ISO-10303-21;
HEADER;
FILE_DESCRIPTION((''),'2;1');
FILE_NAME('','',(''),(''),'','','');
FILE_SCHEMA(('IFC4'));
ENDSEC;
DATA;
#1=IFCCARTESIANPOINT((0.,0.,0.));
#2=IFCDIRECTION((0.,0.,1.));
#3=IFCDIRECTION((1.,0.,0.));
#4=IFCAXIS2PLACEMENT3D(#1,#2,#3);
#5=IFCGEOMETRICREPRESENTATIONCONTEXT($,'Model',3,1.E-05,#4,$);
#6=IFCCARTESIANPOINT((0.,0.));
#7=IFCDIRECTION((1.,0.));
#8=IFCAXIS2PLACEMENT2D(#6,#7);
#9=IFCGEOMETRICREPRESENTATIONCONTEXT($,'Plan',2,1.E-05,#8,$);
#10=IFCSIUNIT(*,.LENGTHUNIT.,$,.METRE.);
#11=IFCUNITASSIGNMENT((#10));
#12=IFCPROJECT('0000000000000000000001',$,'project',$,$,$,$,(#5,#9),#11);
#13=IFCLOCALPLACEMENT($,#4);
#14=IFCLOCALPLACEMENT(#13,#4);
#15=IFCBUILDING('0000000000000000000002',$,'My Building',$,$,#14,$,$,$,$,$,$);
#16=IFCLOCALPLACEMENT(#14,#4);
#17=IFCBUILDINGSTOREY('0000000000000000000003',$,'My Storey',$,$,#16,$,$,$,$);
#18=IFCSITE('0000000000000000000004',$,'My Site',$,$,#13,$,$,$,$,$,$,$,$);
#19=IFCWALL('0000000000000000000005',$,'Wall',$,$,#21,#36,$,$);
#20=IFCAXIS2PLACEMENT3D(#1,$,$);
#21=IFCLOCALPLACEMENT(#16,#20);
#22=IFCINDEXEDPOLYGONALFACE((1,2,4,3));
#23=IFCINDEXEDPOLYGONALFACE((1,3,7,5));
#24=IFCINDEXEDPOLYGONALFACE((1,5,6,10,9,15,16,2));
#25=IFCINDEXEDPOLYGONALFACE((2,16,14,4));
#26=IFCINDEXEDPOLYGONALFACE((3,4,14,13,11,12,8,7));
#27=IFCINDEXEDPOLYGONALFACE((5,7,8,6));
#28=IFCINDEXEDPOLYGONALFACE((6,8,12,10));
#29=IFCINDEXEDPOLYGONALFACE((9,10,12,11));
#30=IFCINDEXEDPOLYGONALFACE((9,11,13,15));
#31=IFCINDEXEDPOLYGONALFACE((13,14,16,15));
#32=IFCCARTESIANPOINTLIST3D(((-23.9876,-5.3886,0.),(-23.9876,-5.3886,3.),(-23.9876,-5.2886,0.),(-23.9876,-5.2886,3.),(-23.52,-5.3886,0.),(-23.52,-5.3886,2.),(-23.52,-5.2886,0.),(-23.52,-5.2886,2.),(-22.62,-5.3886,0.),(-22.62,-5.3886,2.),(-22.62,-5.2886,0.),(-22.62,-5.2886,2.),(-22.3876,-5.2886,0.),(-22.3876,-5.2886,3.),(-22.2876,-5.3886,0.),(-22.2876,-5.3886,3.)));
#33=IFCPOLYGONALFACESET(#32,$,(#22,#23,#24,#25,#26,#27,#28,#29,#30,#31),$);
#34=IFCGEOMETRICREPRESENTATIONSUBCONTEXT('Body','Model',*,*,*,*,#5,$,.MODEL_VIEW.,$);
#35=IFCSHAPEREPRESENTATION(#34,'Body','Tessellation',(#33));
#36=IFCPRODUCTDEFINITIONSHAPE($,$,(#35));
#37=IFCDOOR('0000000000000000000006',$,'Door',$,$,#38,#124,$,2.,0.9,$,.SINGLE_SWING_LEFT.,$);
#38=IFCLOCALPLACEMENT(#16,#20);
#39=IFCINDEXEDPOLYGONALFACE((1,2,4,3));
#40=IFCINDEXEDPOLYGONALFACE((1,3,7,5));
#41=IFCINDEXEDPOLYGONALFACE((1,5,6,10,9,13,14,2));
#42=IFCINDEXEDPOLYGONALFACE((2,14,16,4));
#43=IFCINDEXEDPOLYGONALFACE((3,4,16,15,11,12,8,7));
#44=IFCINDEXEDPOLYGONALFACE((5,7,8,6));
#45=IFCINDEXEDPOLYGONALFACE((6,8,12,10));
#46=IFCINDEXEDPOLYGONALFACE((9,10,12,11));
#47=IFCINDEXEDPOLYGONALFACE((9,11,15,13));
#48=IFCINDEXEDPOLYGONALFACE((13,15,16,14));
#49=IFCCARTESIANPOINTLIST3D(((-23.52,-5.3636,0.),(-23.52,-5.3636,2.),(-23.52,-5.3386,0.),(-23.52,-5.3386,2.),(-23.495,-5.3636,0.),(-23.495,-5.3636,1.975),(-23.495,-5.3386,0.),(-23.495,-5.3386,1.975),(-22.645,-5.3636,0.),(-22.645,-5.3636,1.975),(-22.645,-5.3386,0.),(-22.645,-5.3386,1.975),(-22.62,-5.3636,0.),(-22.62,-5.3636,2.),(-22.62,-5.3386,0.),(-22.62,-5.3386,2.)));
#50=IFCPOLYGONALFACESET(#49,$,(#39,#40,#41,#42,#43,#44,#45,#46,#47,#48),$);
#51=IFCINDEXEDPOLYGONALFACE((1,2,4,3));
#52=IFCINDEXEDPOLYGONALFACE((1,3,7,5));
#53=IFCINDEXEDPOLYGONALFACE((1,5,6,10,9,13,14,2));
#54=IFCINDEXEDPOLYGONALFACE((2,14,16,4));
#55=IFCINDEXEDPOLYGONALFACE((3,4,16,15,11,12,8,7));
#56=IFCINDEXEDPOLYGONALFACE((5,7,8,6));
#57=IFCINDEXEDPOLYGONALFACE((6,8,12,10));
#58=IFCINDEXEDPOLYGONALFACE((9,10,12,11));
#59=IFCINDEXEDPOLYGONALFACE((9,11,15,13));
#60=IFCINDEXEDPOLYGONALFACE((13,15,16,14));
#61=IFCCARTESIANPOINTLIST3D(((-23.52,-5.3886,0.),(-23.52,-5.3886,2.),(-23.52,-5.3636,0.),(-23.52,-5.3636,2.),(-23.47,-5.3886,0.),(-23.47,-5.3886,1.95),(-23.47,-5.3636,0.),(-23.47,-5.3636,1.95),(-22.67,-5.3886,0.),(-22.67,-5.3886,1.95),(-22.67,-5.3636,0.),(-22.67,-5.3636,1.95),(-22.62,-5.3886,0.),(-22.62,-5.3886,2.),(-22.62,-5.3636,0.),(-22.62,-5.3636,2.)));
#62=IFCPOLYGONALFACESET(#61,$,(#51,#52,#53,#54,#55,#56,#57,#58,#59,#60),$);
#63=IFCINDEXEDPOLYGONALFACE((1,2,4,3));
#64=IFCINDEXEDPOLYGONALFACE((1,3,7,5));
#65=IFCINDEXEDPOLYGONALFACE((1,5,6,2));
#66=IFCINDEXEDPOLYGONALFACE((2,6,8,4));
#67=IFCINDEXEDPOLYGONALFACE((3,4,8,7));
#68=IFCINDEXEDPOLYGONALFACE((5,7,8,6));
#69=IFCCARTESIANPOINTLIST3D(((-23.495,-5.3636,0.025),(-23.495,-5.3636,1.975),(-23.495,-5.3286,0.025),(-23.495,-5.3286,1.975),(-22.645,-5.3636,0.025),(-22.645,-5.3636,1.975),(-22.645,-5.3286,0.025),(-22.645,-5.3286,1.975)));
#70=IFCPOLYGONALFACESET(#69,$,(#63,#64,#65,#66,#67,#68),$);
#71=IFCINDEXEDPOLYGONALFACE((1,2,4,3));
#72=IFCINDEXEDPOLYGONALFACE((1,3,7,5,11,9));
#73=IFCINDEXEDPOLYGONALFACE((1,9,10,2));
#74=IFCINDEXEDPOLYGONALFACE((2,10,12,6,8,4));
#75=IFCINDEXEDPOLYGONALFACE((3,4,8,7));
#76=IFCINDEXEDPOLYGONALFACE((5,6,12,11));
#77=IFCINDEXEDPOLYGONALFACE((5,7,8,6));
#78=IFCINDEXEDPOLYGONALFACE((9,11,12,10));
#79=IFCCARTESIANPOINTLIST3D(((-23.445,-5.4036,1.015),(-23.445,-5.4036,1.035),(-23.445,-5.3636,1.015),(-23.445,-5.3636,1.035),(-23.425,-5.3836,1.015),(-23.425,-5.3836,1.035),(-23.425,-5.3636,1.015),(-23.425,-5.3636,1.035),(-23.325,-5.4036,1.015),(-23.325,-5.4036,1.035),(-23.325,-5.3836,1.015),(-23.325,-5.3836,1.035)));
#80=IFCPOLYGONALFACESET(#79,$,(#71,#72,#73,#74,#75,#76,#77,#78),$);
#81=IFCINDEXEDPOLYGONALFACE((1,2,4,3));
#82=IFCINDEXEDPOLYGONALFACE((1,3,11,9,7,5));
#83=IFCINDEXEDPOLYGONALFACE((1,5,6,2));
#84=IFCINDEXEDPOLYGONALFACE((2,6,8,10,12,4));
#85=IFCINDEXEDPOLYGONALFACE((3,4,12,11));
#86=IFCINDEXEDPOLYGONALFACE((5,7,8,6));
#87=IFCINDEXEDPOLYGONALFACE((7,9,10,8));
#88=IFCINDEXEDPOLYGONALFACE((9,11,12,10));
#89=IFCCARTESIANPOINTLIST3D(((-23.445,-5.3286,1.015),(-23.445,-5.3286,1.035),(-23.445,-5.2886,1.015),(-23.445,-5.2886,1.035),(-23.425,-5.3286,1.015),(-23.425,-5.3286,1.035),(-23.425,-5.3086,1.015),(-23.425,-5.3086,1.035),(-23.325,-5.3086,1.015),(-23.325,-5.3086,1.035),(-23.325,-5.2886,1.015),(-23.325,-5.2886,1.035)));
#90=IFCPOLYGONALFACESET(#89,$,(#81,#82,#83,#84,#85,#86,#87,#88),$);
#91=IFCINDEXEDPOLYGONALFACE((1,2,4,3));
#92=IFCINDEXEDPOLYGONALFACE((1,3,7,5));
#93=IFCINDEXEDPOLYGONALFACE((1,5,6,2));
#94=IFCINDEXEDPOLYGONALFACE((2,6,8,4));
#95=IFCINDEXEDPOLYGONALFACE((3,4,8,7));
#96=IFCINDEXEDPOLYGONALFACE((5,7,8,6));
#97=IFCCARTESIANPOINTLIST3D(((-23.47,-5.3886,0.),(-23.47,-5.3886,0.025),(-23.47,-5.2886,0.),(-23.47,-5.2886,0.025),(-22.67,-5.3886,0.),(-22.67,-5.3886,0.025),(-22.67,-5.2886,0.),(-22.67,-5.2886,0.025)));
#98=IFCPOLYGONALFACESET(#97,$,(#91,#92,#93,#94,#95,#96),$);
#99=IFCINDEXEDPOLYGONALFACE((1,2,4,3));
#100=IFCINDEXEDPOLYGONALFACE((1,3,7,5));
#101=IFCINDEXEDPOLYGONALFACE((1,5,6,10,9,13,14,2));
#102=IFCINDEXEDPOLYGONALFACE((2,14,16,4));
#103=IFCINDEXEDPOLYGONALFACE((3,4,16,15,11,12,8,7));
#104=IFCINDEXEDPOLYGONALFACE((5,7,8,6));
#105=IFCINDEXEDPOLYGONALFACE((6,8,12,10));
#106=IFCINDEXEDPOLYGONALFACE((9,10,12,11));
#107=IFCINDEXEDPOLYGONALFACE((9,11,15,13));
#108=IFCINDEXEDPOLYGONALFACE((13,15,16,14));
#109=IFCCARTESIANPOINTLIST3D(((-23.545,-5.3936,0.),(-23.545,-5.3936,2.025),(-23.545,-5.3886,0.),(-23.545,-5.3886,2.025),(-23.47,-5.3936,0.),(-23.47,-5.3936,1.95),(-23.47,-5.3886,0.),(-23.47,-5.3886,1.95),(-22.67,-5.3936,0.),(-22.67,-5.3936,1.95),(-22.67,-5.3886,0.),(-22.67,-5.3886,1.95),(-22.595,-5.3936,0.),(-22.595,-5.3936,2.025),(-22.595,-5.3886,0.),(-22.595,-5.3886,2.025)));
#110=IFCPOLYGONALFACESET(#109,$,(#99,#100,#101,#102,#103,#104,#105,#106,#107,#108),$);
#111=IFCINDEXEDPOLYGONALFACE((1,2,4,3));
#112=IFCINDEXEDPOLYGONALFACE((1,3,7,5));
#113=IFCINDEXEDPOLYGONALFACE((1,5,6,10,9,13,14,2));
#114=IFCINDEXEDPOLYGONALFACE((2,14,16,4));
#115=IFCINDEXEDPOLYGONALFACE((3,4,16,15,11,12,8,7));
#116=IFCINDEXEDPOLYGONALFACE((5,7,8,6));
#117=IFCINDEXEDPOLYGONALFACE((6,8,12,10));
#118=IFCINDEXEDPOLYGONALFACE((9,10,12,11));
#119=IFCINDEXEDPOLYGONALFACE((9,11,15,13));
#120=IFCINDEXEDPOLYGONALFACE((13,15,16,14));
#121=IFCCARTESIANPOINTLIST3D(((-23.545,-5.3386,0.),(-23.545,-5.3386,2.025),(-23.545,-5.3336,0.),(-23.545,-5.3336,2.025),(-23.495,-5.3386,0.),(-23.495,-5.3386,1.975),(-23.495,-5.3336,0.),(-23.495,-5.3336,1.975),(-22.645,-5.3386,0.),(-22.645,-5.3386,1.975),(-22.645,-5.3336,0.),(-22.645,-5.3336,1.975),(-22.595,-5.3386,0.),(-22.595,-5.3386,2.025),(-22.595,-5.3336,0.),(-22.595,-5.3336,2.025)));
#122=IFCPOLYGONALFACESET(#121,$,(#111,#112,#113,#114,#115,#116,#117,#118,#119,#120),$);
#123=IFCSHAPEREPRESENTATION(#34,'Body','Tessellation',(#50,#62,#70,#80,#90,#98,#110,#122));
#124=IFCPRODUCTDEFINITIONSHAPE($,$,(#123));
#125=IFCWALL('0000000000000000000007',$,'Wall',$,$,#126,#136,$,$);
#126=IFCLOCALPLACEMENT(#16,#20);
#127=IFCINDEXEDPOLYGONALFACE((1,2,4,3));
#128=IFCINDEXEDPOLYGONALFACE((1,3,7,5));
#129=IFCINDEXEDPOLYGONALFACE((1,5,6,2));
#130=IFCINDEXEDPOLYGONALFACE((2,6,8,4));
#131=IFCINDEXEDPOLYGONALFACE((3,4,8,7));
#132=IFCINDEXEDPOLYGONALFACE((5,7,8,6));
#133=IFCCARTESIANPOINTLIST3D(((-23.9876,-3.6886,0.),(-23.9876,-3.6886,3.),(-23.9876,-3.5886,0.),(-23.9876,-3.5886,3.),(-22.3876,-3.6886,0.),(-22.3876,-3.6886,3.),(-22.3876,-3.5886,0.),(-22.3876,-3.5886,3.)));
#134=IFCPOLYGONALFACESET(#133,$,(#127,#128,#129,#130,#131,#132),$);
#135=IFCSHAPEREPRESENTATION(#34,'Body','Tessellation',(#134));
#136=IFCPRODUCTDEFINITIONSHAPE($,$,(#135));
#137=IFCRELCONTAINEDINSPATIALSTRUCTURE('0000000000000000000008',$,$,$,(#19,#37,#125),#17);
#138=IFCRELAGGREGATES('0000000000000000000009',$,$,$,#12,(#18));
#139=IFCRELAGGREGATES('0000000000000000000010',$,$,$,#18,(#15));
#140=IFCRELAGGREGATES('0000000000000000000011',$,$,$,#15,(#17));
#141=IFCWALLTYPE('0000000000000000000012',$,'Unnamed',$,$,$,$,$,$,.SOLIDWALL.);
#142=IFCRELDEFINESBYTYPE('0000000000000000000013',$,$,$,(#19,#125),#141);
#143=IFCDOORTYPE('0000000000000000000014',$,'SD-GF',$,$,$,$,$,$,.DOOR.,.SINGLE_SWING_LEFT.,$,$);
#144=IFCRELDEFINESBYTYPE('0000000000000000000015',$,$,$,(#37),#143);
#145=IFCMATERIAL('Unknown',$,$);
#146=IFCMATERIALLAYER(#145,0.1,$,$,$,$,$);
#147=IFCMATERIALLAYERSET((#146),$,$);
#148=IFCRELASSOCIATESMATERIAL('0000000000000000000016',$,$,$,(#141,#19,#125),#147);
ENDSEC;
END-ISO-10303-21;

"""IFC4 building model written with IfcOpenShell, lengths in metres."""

from ifc_helpers import new_model, entity, si_unit, frame, origin_with_axes, origin_2d_with_axis, place, context, subcontext, project, spatial, line, indexed_curve, outline, extrude, shape, source, transform, mapped, material, layer, layer_set, layer_usage, type_object, type_shapes, element, fill, save


model = new_model("IFC4")

# Units and contexts
model_context = context("Model", 3, precision=1e-05, world=origin_with_axes())
plan_context = context("Plan", 2, precision=1e-05, world=origin_2d_with_axis())
body_context_1 = subcontext(model_context, "Body", "Model", "MODEL_VIEW")
body_context_2 = subcontext(plan_context, "Body", "Plan", "PLAN_VIEW")
ifc_project = project(units=[si_unit("LENGTHUNIT", "METRE")], contexts=[model_context, plan_context])

# Site, building, storey
site_placement = place(None, origin_with_axes())
site = spatial("IfcSite", under=ifc_project, at=site_placement, Name="My Site")
building_placement = place(site_placement, origin_with_axes())
building = spatial("IfcBuilding", under=site, at=building_placement, Name="My Building")
storey_placement = place(building_placement, origin_with_axes())
storey = spatial("IfcBuildingStorey", under=building, at=storey_placement, Name="My Storey")

# Shared definitions
ifc_material = material(Name="Unknown")

# Shared definitions
ifc_layer = layer(ifc_material, 0.1)
ifc_layer_set = layer_set([ifc_layer])
wall_type = type_object("IfcWallType", Name="Unnamed", PredefinedType="SOLIDWALL", material=ifc_layer_set)

# Wall, opening, door
shared_shape_1 = source(origin_with_axes(), body_context_1, "Body", "SweptSolid", [
    extrude(outline(indexed_curve([(0.0, 0.0), (0.9, 0.0), (0.9, 2.0), (0.0, 2.0)], segments=[line(1, 2, 3, 4, 1)])), frame((0.0, -0.6, 0.0), z_axis=(0.0, -1.0, 0.0), x_axis=(1.0, 0.0, 0.0)), (0.0, 0.0, -1.0), 1.2),
])
door_type = type_object("IfcDoorType", Name="SD-GF", OperationType="SINGLE_SWING_LEFT", PredefinedType="DOOR")
shared_shape_2 = source(origin_with_axes(), body_context_1, "Body", "SweptSolid", [
    extrude(outline(indexed_curve([(0.0, 0.0), (0.0, 2.0), (0.9, 2.0), (0.9, 0.0), (0.875, 0.0), (0.875, 1.975), (0.025, 1.975), (0.025, 0.0)], segments=[line(1, 2, 3, 4, 5, 6, 7, 8, 1)])), frame((0.0, 0.025, 0.0), z_axis=(0.0, -1.0, 0.0), x_axis=(1.0, 0.0, 0.0)), (0.0, 0.0, -1.0), 0.025),
    extrude(outline(indexed_curve([(0.0, 0.0), (0.0, 2.0), (0.9, 2.0), (0.9, 0.0), (0.85, 0.0), (0.85, 1.95), (0.05, 1.95), (0.05, 0.0)], segments=[line(1, 2, 3, 4, 5, 6, 7, 8, 1)])), frame((0.0, 0.0, 0.0), z_axis=(0.0, -1.0, 0.0), x_axis=(1.0, 0.0, 0.0)), (0.0, 0.0, -1.0), 0.025),
    extrude(outline(indexed_curve([(0.0, 0.0), (0.85, 0.0), (0.85, 0.035), (0.0, 0.035)], segments=[line(1, 2, 3, 4, 1)])), frame((0.025, 0.025, 0.025), z_axis=(0.0, 0.0, 1.0), x_axis=(1.0, 0.0, 0.0)), (0.0, 0.0, 1.0), 1.95),
    extrude(outline(indexed_curve([(0.0, 0.0), (0.0, -0.04), (0.12, -0.04), (0.12, -0.02), (0.02, -0.02), (0.02, 0.0)], segments=[line(1, 2, 3, 4, 5, 6, 1)])), frame((0.075, 0.025, 1.015), z_axis=(0.0, 0.0, 1.0), x_axis=(1.0, 0.0, 0.0)), (0.0, 0.0, 1.0), 0.02),
    extrude(outline(indexed_curve([(0.0, 0.0), (0.0, 0.04), (0.12, 0.04), (0.12, 0.02), (0.02, 0.02), (0.02, 0.0)], segments=[line(1, 2, 3, 4, 5, 6, 1)])), frame((0.075, 0.06, 1.015), z_axis=(0.0, 0.0, 1.0), x_axis=(1.0, 0.0, 0.0)), (0.0, 0.0, 1.0), 0.02),
    extrude(outline(indexed_curve([(0.0, 0.0), (0.8, 0.0), (0.8, 0.1), (0.0, 0.1)], segments=[line(1, 2, 3, 4, 1)])), frame((0.05, 0.0, 0.0), z_axis=(0.0, 0.0, 1.0), x_axis=(1.0, 0.0, 0.0)), (0.0, 0.0, 1.0), 0.025),
    extrude(outline(indexed_curve([(0.0, 0.0), (0.0, 2.025), (0.95, 2.025), (0.95, 0.0), (0.875, 0.0), (0.875, 1.95), (0.075, 1.95), (0.075, 0.0)], segments=[line(1, 2, 3, 4, 5, 6, 7, 8, 1)])), frame((-0.025, -0.005, 0.0), z_axis=(0.0, -1.0, 0.0), x_axis=(1.0, 0.0, 0.0)), (0.0, 0.0, -1.0), 0.005),
    extrude(outline(indexed_curve([(0.0, 0.0), (0.0, 2.025), (0.95, 2.025), (0.95, 0.0), (0.9, 0.0), (0.9, 1.975), (0.05, 1.975), (0.05, 0.0)], segments=[line(1, 2, 3, 4, 5, 6, 7, 8, 1)])), frame((-0.025, 0.05, 0.0), z_axis=(0.0, -1.0, 0.0), x_axis=(1.0, 0.0, 0.0)), (0.0, 0.0, -1.0), 0.005),
])
shared_shape_3 = source(origin_with_axes(), body_context_2, "Body", "Curve2D", [
    entity("IfcIndexedPolyCurve", entity("IfcCartesianPointList2D", [[0.0, 0.0], [0.0, 0.05], [0.025, 0.05], [0.025, 0.025], [0.05, 0.025], [0.05, 0.0]]), [entity("IfcLineIndex", [1, 2, 3, 4, 5, 6, 1])]),
    entity("IfcIndexedPolyCurve", entity("IfcCartesianPointList2D", [[0.9, 0.0], [0.9, 0.05], [0.875, 0.05], [0.875, 0.025], [0.85, 0.025], [0.85, 0.0]]), [entity("IfcLineIndex", [1, 2, 3, 4, 5, 6, 1])]),
    entity("IfcTrimmedCurve", entity("IfcEllipse", entity("IfcAxis2Placement2D", entity("IfcCartesianPoint", [0.84, 0.05]), entity("IfcDirection", [1.0, 0.0])), 0.815, 0.85), [entity("IfcCartesianPoint", [0.84, 0.9])], [entity("IfcCartesianPoint", [0.025, 0.05])], True, "CARTESIAN"),
    entity("IfcIndexedPolyCurve", entity("IfcCartesianPointList2D", [[0.875, 0.05], [0.84, 0.05], [0.84, 0.9], [0.875, 0.9]]), [entity("IfcLineIndex", [1, 2, 3, 4, 1])]),
])
type_shapes(door_type, [shared_shape_2, shared_shape_3])
ifc_layer_usage_1 = layer_usage(ifc_layer_set, "AXIS2", "POSITIVE", 0.0)
wall_1_placement = place(storey_placement, frame((-22.3876, -5.2886, 0.0), z_axis=(0.0, 0.0, 1.0), x_axis=(-1.0, 0.0, 0.0)))
wall_1 = element("IfcWall", 1, at=wall_1_placement, inside=storey, type_object=wall_type, material=ifc_layer_usage_1, Name="Wall", context=body_context_1, shape_type="SweptSolid", body=[
    extrude(outline(indexed_curve([(0.0, 0.0), (-0.1, 0.1), (1.6, 0.1), (1.6, 0.0)], segments=[line(1, 2, 3, 4, 1)])), origin_with_axes(), (0.0, 0.0, 1.0), 3.0),
])
opening_1_placement = place(wall_1_placement, frame((1.1325, 0.1, 0.0), z_axis=(0.0, 0.0, 1.0), x_axis=(-1.0, 0.0, 0.0)))
opening_1 = element("IfcOpeningElement", 2, at=opening_1_placement, cuts=wall_1, PredefinedType="OPENING", context=body_context_1, shape_type="MappedRepresentation", body=[
    mapped(shared_shape_1, transform((0.0, 0.0, 0.0), x_axis=(1.0, 0.0, 0.0), y_axis=(0.0, 1.0, 0.0), z_axis=(0.0, 0.0, 1.0), scale=1.0)),
])
door_1_placement = place(opening_1_placement, frame((0.0, 0.0, 0.0), z_axis=(0.0, 0.0, 1.0), x_axis=(1.0, 0.0, 0.0)))
door_1 = element("IfcDoor", 3, at=door_1_placement, inside=storey, type_object=door_type, Name="Door", OperationType="SINGLE_SWING_LEFT", OverallHeight=2.0, OverallWidth=0.9, shapes=[
    shape(body_context_1, "Body", "MappedRepresentation", [mapped(shared_shape_2, transform((0.0, 0.0, 0.0), x_axis=(1.0, 0.0, 0.0), y_axis=(0.0, 1.0, 0.0), z_axis=(0.0, 0.0, 1.0), scale=1.0))]),
    shape(body_context_2, "Body", "MappedRepresentation", [mapped(shared_shape_3, transform((0.0, 0.0, 0.0), x_axis=(1.0, 0.0, 0.0), y_axis=(0.0, 1.0, 0.0), z_axis=(0.0, 0.0, 1.0), scale=1.0))]),
])
fill(opening_1, door_1)

# Wall
ifc_layer_usage_2 = layer_usage(ifc_layer_set, "AXIS2", "POSITIVE", 0.0)
wall_2_placement = place(storey_placement, frame((-22.3876, -3.5886, 0.0), z_axis=(0.0, 0.0, 1.0), x_axis=(-1.0, 0.0, 0.0)))
element("IfcWall", 4, at=wall_2_placement, inside=storey, type_object=wall_type, material=ifc_layer_usage_2, Name="Wall", context=body_context_1, shape_type="SweptSolid", body=[
    extrude(outline(indexed_curve([(0.0, 0.0), (0.0, 0.1), (1.6, 0.1), (1.6, 0.0)], segments=[line(1, 2, 3, 4, 1)])), origin_with_axes(), (0.0, 0.0, 1.0), 3.0),
])

save(model, "model.ifc")
